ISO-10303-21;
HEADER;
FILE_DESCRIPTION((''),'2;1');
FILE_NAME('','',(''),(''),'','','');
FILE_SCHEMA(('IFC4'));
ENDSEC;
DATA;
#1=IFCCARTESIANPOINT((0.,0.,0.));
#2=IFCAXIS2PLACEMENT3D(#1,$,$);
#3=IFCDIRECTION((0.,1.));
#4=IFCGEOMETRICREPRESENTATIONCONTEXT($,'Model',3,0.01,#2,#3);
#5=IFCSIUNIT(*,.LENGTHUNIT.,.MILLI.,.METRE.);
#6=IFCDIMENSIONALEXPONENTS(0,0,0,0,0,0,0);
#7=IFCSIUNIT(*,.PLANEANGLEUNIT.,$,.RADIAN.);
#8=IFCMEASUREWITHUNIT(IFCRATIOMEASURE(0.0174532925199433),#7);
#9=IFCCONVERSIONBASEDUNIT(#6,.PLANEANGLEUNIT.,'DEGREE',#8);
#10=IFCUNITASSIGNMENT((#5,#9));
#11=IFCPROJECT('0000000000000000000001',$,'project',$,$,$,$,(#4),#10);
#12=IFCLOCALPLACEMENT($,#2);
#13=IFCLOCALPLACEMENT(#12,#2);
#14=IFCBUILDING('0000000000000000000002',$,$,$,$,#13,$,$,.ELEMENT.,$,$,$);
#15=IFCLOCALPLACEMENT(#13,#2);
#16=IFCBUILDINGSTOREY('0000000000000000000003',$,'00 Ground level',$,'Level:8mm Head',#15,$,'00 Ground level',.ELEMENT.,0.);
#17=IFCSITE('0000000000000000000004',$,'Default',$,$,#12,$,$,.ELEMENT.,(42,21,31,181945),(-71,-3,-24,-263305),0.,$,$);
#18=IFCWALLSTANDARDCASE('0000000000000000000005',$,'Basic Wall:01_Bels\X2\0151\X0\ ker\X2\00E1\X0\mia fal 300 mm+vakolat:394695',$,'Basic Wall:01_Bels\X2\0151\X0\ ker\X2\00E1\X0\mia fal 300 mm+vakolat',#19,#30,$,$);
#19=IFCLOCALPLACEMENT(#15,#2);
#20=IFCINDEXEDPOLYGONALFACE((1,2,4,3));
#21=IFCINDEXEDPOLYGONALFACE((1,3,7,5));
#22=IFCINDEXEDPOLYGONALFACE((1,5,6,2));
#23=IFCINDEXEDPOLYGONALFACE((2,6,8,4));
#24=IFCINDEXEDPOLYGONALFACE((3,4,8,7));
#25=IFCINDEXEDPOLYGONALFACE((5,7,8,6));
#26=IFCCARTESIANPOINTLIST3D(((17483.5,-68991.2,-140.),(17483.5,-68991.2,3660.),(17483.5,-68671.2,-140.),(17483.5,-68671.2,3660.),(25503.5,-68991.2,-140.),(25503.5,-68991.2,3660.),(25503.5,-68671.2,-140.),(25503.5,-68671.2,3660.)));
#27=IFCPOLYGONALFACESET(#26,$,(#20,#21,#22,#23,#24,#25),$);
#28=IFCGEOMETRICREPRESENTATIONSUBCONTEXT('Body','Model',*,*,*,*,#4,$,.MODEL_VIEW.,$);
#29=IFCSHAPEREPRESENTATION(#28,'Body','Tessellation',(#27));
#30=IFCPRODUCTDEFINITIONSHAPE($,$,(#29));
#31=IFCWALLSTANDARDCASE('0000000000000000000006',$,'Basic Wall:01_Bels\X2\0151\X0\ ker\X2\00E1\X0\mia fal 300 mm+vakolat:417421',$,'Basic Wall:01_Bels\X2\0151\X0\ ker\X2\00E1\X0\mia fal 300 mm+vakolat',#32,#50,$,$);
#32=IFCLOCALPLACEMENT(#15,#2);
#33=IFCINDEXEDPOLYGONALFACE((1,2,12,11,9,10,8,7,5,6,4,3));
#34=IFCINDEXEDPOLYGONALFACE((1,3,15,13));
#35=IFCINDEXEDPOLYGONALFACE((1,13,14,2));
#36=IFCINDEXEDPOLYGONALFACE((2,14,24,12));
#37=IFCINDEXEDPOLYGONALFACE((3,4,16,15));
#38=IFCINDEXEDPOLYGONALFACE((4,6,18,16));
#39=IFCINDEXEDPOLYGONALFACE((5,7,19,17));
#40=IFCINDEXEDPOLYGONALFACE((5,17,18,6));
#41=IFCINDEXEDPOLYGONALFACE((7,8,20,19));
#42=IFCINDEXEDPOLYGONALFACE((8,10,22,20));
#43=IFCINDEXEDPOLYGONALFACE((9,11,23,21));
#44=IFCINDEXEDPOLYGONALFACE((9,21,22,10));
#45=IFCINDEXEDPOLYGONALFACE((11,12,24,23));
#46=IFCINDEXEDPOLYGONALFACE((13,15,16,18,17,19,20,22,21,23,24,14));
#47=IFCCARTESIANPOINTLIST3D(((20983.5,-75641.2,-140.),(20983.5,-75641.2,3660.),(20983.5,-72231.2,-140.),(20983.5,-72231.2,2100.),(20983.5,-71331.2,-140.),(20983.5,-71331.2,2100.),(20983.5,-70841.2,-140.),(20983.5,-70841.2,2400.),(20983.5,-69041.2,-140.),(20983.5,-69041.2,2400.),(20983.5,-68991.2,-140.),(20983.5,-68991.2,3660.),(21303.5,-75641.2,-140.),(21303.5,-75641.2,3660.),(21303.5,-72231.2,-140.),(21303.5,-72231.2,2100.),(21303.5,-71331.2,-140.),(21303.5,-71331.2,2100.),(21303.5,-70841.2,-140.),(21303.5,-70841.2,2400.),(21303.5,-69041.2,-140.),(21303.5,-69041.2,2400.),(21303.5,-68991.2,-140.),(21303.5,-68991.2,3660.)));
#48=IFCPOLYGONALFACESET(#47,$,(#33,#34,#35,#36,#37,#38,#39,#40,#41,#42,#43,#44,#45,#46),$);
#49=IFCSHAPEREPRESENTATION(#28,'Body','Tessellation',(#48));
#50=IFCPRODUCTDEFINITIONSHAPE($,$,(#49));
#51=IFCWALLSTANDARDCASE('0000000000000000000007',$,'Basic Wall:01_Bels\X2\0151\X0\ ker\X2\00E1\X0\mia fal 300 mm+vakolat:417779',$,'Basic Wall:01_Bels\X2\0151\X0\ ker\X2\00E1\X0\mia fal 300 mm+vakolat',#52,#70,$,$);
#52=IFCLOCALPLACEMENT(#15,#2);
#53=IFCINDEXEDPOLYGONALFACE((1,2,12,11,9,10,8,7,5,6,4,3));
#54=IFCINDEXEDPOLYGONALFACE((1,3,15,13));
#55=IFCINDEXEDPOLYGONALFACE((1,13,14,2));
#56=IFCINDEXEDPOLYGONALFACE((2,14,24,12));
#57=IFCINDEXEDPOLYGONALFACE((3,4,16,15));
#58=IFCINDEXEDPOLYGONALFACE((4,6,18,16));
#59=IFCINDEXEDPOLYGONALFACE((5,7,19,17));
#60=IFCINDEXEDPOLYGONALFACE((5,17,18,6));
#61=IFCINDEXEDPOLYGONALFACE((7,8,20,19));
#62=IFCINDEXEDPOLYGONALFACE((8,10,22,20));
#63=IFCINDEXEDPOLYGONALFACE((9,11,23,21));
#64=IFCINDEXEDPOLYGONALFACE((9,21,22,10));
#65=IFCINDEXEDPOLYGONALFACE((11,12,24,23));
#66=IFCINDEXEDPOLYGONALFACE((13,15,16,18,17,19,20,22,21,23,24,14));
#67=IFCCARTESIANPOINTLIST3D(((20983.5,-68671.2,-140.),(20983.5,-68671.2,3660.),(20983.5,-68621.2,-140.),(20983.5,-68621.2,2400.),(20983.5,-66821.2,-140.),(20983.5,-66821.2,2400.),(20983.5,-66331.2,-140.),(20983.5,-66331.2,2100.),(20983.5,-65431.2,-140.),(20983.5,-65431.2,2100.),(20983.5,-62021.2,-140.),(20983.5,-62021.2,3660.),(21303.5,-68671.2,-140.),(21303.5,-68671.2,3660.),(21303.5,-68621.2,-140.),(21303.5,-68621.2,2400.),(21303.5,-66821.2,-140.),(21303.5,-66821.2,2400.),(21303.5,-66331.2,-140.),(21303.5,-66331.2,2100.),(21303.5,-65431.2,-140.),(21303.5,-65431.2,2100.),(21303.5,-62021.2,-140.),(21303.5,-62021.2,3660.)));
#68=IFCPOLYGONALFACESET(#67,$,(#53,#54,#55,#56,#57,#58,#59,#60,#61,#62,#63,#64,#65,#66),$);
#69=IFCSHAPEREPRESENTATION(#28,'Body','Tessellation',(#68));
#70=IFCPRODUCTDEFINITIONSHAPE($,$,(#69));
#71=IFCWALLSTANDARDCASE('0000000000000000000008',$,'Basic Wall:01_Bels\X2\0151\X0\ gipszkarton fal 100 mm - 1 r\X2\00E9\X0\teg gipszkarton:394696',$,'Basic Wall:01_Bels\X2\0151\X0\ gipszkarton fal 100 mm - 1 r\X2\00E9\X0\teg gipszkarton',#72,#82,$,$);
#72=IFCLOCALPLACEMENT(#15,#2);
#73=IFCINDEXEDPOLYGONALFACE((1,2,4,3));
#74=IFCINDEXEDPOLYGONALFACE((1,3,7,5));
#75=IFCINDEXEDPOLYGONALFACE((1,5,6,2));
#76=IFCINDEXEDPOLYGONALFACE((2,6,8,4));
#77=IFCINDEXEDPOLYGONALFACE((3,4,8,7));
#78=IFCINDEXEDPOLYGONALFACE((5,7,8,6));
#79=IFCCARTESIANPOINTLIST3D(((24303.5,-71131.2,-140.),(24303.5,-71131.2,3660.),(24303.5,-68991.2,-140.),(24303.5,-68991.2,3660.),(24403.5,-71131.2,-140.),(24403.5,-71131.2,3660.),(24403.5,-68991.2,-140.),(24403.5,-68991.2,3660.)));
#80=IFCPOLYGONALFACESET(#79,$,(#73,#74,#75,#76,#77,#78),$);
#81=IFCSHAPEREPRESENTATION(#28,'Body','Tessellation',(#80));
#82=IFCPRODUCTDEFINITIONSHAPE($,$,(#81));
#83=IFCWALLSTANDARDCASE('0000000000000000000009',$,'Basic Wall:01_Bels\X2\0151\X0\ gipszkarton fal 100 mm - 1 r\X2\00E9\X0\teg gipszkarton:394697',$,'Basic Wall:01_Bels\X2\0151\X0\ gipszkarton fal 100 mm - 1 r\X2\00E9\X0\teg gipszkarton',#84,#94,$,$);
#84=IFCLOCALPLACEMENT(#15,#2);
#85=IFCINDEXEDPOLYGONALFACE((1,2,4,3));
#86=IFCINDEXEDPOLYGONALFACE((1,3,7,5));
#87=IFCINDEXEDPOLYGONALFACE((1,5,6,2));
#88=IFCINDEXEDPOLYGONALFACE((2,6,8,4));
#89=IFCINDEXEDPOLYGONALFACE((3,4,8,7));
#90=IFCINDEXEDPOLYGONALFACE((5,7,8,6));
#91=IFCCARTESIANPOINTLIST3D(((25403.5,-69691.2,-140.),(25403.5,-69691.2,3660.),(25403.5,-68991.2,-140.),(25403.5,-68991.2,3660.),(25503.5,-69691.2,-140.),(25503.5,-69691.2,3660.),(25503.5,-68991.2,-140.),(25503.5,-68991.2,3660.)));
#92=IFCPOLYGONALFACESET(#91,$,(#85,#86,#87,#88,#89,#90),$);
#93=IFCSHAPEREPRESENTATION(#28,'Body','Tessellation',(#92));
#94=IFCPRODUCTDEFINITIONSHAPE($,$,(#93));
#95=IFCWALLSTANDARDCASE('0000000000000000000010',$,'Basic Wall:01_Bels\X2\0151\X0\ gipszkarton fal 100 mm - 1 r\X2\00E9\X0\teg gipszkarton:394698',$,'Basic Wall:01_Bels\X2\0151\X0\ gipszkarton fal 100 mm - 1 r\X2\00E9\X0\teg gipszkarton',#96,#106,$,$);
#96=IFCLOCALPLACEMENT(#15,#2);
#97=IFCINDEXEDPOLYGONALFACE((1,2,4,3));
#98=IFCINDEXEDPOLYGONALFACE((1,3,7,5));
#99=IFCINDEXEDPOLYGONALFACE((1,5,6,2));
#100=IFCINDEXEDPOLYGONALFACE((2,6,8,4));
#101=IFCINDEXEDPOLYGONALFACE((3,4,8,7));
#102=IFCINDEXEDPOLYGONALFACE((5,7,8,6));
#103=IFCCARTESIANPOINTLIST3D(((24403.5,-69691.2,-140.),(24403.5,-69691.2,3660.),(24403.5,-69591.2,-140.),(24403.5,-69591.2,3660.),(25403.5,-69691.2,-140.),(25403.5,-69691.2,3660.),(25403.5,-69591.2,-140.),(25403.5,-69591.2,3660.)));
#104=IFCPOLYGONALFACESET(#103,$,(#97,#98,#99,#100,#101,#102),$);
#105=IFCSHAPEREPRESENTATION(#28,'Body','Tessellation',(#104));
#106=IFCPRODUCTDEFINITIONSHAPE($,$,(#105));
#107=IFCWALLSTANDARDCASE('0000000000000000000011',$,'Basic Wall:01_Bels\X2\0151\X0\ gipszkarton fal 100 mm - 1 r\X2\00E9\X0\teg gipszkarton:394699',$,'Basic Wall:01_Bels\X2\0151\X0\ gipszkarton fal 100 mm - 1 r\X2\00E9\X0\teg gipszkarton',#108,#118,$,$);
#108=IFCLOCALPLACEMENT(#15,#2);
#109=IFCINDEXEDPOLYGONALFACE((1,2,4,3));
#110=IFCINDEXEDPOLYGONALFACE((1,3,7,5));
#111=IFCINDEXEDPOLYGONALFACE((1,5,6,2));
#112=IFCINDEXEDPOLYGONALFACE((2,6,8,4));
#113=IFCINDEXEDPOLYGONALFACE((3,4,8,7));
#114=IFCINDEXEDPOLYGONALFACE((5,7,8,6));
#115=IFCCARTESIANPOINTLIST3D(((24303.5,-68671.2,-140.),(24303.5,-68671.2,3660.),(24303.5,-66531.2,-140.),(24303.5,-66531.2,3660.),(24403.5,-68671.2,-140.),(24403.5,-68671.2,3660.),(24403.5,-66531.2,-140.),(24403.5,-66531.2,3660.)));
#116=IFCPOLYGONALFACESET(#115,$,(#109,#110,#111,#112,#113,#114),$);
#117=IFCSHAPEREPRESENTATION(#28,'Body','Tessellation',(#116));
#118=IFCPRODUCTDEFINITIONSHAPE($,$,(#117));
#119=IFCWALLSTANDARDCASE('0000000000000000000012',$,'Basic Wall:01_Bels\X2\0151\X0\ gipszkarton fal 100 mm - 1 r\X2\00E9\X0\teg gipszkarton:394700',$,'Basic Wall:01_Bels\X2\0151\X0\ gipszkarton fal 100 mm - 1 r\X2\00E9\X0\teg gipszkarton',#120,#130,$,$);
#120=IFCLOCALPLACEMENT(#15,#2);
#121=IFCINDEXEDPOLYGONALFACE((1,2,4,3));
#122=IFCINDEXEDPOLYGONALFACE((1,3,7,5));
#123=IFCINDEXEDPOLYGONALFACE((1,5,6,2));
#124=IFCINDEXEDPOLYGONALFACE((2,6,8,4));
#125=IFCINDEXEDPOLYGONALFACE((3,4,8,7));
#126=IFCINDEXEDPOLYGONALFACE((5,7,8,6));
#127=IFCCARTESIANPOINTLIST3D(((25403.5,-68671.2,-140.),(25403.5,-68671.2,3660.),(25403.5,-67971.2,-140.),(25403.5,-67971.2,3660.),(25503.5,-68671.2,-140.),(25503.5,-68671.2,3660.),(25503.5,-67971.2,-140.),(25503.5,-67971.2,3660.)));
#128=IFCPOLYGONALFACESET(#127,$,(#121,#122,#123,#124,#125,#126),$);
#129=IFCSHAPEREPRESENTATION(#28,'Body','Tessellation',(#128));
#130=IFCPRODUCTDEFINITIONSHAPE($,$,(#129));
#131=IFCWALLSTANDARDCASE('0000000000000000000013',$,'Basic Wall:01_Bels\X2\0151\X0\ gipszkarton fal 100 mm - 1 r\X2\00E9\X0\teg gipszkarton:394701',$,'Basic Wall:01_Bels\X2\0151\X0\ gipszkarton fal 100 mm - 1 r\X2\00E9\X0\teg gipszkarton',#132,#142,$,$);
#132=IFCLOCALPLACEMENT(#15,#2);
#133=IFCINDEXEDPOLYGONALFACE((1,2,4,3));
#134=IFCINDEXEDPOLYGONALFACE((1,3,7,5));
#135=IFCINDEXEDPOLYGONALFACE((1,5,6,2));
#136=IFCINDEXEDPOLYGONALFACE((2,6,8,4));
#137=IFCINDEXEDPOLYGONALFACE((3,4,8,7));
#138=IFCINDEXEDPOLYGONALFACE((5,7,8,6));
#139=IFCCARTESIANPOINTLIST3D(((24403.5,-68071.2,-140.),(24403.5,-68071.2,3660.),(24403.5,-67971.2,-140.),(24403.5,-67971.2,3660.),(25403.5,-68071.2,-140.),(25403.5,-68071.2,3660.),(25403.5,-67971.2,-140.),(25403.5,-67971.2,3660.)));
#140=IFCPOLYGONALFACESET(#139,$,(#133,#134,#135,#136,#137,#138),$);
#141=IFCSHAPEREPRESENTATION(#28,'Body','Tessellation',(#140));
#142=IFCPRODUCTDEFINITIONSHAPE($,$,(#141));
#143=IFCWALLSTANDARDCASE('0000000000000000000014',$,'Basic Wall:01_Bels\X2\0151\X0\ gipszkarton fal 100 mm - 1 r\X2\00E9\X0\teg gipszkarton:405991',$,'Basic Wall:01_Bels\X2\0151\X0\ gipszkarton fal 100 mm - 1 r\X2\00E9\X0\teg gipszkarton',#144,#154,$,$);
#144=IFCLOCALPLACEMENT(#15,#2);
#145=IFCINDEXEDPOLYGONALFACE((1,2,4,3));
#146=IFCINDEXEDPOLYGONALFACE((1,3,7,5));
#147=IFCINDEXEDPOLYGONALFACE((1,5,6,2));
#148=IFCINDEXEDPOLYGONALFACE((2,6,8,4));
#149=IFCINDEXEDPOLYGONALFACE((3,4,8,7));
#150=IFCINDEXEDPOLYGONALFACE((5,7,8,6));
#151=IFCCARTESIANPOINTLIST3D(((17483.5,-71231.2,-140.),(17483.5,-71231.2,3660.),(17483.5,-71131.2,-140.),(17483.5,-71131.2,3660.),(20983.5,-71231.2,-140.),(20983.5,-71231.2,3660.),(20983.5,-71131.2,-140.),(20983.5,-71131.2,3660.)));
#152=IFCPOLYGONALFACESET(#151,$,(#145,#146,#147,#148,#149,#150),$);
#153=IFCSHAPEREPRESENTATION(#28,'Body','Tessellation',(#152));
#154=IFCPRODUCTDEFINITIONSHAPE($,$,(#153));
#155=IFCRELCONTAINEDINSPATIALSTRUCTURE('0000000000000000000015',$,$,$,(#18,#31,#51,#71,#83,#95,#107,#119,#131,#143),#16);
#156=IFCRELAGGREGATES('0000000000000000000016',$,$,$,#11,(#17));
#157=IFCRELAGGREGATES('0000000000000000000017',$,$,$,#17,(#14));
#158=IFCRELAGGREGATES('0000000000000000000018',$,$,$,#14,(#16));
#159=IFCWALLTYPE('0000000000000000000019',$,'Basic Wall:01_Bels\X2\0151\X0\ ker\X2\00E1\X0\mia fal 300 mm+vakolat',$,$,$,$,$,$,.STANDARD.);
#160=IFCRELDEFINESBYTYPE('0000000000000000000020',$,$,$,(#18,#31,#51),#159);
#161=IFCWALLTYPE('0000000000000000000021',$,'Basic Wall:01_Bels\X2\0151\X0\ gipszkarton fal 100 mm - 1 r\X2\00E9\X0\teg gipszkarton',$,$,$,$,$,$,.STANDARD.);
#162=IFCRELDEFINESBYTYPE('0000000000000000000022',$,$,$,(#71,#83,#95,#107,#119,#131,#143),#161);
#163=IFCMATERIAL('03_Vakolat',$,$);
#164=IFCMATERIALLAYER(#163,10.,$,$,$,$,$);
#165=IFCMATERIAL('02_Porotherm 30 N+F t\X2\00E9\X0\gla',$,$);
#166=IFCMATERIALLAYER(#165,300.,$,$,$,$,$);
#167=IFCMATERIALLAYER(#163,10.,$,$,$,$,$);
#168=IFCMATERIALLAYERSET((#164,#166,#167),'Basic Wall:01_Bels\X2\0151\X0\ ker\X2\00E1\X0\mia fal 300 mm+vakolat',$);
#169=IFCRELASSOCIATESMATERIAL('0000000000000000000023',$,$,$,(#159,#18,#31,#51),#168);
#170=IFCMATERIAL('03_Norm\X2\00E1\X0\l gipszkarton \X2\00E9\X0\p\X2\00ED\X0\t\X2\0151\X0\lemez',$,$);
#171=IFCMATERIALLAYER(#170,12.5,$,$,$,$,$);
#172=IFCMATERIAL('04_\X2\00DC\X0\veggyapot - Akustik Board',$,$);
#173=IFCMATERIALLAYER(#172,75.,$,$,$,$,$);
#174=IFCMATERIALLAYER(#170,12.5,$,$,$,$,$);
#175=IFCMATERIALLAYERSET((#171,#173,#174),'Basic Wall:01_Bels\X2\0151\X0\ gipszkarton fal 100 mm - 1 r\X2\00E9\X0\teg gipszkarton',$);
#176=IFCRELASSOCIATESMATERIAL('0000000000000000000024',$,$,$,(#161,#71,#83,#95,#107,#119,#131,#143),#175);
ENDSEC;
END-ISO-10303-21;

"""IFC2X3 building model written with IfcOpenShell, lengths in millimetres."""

from ifc_helpers import new_model, entity, si_unit, converted_unit, direction, frame, frame_2d, origin, origin_2d_with_axis, place, context, subcontext, project, spatial, rectangle, extrude, material, layer, layer_set, layer_usage, type_object, element, save


model = new_model("IFC2X3")

# Units and contexts
model_context = context("Model", 3, precision=0.01, world=origin(), true_north=direction((0.0, 1.0)))
body_context = subcontext(model_context, "Body", "Model", "MODEL_VIEW")
ifc_project = project(units=[si_unit("LENGTHUNIT", "METRE", prefix="MILLI"), converted_unit("PLANEANGLEUNIT", "DEGREE", entity("IfcRatioMeasure", 0.0174532925199433), si_unit("PLANEANGLEUNIT", "RADIAN"), dimensions=[0, 0, 0, 0, 0, 0, 0])], contexts=[model_context])

# Site, building, storey
site_placement = place(None, origin())
site = spatial("IfcSite", under=ifc_project, at=site_placement, Name="Default", CompositionType="ELEMENT", RefLatitude=(42, 21, 31, 181945), RefLongitude=(-71, -3, -24, -263305), RefElevation=0.0)
building_placement = place(site_placement, origin())
building = spatial("IfcBuilding", under=site, at=building_placement, CompositionType="ELEMENT")
storey_placement = place(building_placement, origin())
storey = spatial("IfcBuildingStorey", under=building, at=storey_placement, Name="00 Ground level", ObjectType="Level:8mm Head", LongName="00 Ground level", CompositionType="ELEMENT", Elevation=0.0)

# Wall
ifc_material_1 = material(Name="03_Vakolat")
ifc_layer_1 = layer(ifc_material_1, 10.0)
ifc_material_2 = material(Name="02_Porotherm 30 N+F tégla")
ifc_layer_2 = layer(ifc_material_2, 300.0)
ifc_layer_3 = layer(ifc_material_1, 10.0)
ifc_layer_set_1 = layer_set([ifc_layer_1, ifc_layer_2, ifc_layer_3], Name="Basic Wall:01_Belső kerámia fal 300 mm+vakolat")
ifc_layer_usage_1 = layer_usage(ifc_layer_set_1, "AXIS2", "NEGATIVE", 160.0)
wall_type_1 = type_object("IfcWallType", Name="Basic Wall:01_Belső kerámia fal 300 mm+vakolat", PredefinedType="STANDARD", material=ifc_layer_set_1)
wall_1_placement = place(storey_placement, frame((17483.5, -68831.2, -140.0)))
element("IfcWallStandardCase", 1, at=wall_1_placement, inside=storey, type_object=wall_type_1, material=ifc_layer_usage_1, Name="Basic Wall:01_Belső kerámia fal 300 mm+vakolat:394695", ObjectType="Basic Wall:01_Belső kerámia fal 300 mm+vakolat", context=body_context, shape_type="SweptSolid", body=[
    extrude(rectangle(XDim=8020.0, YDim=320.0, at=frame_2d((4010.0, 0.0), x_axis=(-1.0, 0.0))), origin(), (0.0, 0.0, 1.0), 3800.0),
])

# Walls, openings
ifc_layer_usage_2 = layer_usage(ifc_layer_set_1, "AXIS2", "NEGATIVE", 160.0)
wall_2_placement = place(storey_placement, frame((21143.5, -75641.2, -140.0), z_axis=(0.0, 0.0, 1.0), x_axis=(0.0, 1.0, 0.0)))
wall_2 = element("IfcWallStandardCase", 2, at=wall_2_placement, inside=storey, type_object=wall_type_1, material=ifc_layer_usage_2, Name="Basic Wall:01_Belső kerámia fal 300 mm+vakolat:417421", ObjectType="Basic Wall:01_Belső kerámia fal 300 mm+vakolat", context=body_context, shape_type="SweptSolid", body=[
    extrude(rectangle(XDim=6650.0, YDim=320.0, at=frame_2d((3325.0, 0.0), x_axis=(-1.0, 0.0))), origin(), (0.0, 0.0, 1.0), 3800.0),
])
opening_1_placement = place(wall_2_placement, frame((4800.0, 160.0, 0.0)))
element("IfcOpeningElement", 3, at=opening_1_placement, cuts=wall_2, ObjectType="Opening", context=body_context, shape_type="SweptSolid", body=[
    extrude(rectangle(XDim=2540.0, YDim=1800.0, at=frame_2d((0.0, 0.0), x_axis=(1.0, 0.0))), frame((900.0, -320.0, 1270.0), z_axis=(0.0, 1.0, 0.0), x_axis=(0.0, 0.0, -1.0)), (0.0, 0.0, 1.0), 320.0),
])
opening_2_placement = place(wall_2_placement, frame((3410.0, 1364.0, 0.0), z_axis=(0.0, 0.0, 1.0), x_axis=(0.0, -1.0, 0.0)))
element("IfcOpeningElement", 4, at=opening_2_placement, cuts=wall_2, ObjectType="Opening", context=body_context, shape_type="SweptSolid", body=[
    extrude(rectangle(XDim=2240.0, YDim=900.0, at=origin_2d_with_axis()), frame((3048.0, 450.0, 1120.0), z_axis=(-1.0, 0.0, 0.0), x_axis=(0.0, 0.0, 1.0)), (0.0, 0.0, 1.0), 3048.0),
])
ifc_layer_usage_3 = layer_usage(ifc_layer_set_1, "AXIS2", "POSITIVE", -160.0)
wall_3_placement = place(storey_placement, frame((21143.5, -62021.2, -140.0), z_axis=(0.0, 0.0, 1.0), x_axis=(0.0, -1.0, 0.0)))
wall_3 = element("IfcWallStandardCase", 5, at=wall_3_placement, inside=storey, type_object=wall_type_1, material=ifc_layer_usage_3, Name="Basic Wall:01_Belső kerámia fal 300 mm+vakolat:417779", ObjectType="Basic Wall:01_Belső kerámia fal 300 mm+vakolat", context=body_context, shape_type="SweptSolid", body=[
    extrude(rectangle(XDim=6650.0, YDim=320.0, at=frame_2d((3325.0, 0.0), x_axis=(-1.0, 0.0))), origin(), (0.0, 0.0, 1.0), 3800.0),
])
opening_3_placement = place(wall_3_placement, frame((6600.0, -160.0, 0.0)))
element("IfcOpeningElement", 6, at=opening_3_placement, cuts=wall_3, ObjectType="Opening", context=body_context, shape_type="SweptSolid", body=[
    extrude(rectangle(XDim=2540.0, YDim=1800.0, at=frame_2d((0.0, 0.0), x_axis=(1.0, 0.0))), frame((-900.0, 0.0, 1270.0), z_axis=(0.0, 1.0, 0.0), x_axis=(0.0, 0.0, -1.0)), (0.0, 0.0, 1.0), 320.0),
])
opening_4_placement = place(wall_3_placement, frame((4310.0, -1364.0, 0.0), z_axis=(0.0, 0.0, 1.0), x_axis=(0.0, 1.0, 0.0)))
element("IfcOpeningElement", 7, at=opening_4_placement, cuts=wall_3, ObjectType="Opening", context=body_context, shape_type="SweptSolid", body=[
    extrude(rectangle(XDim=2240.0, YDim=900.0, at=origin_2d_with_axis()), frame((0.0, 450.0, 1120.0), z_axis=(1.0, 0.0, 0.0), x_axis=(0.0, 0.0, 1.0)), (0.0, 0.0, 1.0), 3048.0),
])

# Walls
ifc_material_3 = material(Name="03_Normál gipszkarton építőlemez")
ifc_layer_4 = layer(ifc_material_3, 12.5)
ifc_material_4 = material(Name="04_Üveggyapot - Akustik Board")
ifc_layer_5 = layer(ifc_material_4, 75.0)
ifc_layer_6 = layer(ifc_material_3, 12.5)
ifc_layer_set_2 = layer_set([ifc_layer_4, ifc_layer_5, ifc_layer_6], Name="Basic Wall:01_Belső gipszkarton fal 100 mm - 1 réteg gipszkarton")
ifc_layer_usage_4 = layer_usage(ifc_layer_set_2, "AXIS2", "NEGATIVE", 50.0)
wall_type_2 = type_object("IfcWallType", Name="Basic Wall:01_Belső gipszkarton fal 100 mm - 1 réteg gipszkarton", PredefinedType="STANDARD", material=ifc_layer_set_2)
wall_4_placement = place(storey_placement, frame((24353.5, -71131.2, -140.0), z_axis=(0.0, 0.0, 1.0), x_axis=(0.0, 1.0, 0.0)))
element("IfcWallStandardCase", 8, at=wall_4_placement, inside=storey, type_object=wall_type_2, material=ifc_layer_usage_4, Name="Basic Wall:01_Belső gipszkarton fal 100 mm - 1 réteg gipszkarton:394696", ObjectType="Basic Wall:01_Belső gipszkarton fal 100 mm - 1 réteg gipszkarton", context=body_context, shape_type="SweptSolid", body=[
    extrude(rectangle(XDim=2140.0, YDim=100.0, at=frame_2d((1070.0, 0.0), x_axis=(-1.0, 0.0))), origin(), (0.0, 0.0, 1.0), 3800.0),
])
ifc_layer_usage_5 = layer_usage(ifc_layer_set_2, "AXIS2", "NEGATIVE", 50.0)
wall_5_placement = place(storey_placement, frame((25453.5, -69691.2, -140.0), z_axis=(0.0, 0.0, 1.0), x_axis=(0.0, 1.0, 0.0)))
element("IfcWallStandardCase", 9, at=wall_5_placement, inside=storey, type_object=wall_type_2, material=ifc_layer_usage_5, Name="Basic Wall:01_Belső gipszkarton fal 100 mm - 1 réteg gipszkarton:394697", ObjectType="Basic Wall:01_Belső gipszkarton fal 100 mm - 1 réteg gipszkarton", context=body_context, shape_type="SweptSolid", body=[
    extrude(rectangle(XDim=700.0, YDim=100.0, at=frame_2d((350.0, 0.0), x_axis=(-1.0, 0.0))), origin(), (0.0, 0.0, 1.0), 3800.0),
])
ifc_layer_usage_6 = layer_usage(ifc_layer_set_2, "AXIS2", "NEGATIVE", 50.0)
wall_6_placement = place(storey_placement, frame((24403.5, -69641.2, -140.0)))
element("IfcWallStandardCase", 10, at=wall_6_placement, inside=storey, type_object=wall_type_2, material=ifc_layer_usage_6, Name="Basic Wall:01_Belső gipszkarton fal 100 mm - 1 réteg gipszkarton:394698", ObjectType="Basic Wall:01_Belső gipszkarton fal 100 mm - 1 réteg gipszkarton", context=body_context, shape_type="SweptSolid", body=[
    extrude(rectangle(XDim=1000.0, YDim=100.0, at=frame_2d((500.0, 0.0), x_axis=(-1.0, 0.0))), origin(), (0.0, 0.0, 1.0), 3800.0),
])
ifc_layer_usage_7 = layer_usage(ifc_layer_set_2, "AXIS2", "POSITIVE", -50.0)
wall_7_placement = place(storey_placement, frame((24353.5, -66531.2, -140.0), z_axis=(0.0, 0.0, 1.0), x_axis=(0.0, -1.0, 0.0)))
element("IfcWallStandardCase", 11, at=wall_7_placement, inside=storey, type_object=wall_type_2, material=ifc_layer_usage_7, Name="Basic Wall:01_Belső gipszkarton fal 100 mm - 1 réteg gipszkarton:394699", ObjectType="Basic Wall:01_Belső gipszkarton fal 100 mm - 1 réteg gipszkarton", context=body_context, shape_type="SweptSolid", body=[
    extrude(rectangle(XDim=2140.0, YDim=100.0, at=frame_2d((1070.0, 0.0), x_axis=(-1.0, 0.0))), origin(), (0.0, 0.0, 1.0), 3800.0),
])
ifc_layer_usage_8 = layer_usage(ifc_layer_set_2, "AXIS2", "POSITIVE", -50.0)
wall_8_placement = place(storey_placement, frame((25453.5, -67971.2, -140.0), z_axis=(0.0, 0.0, 1.0), x_axis=(0.0, -1.0, 0.0)))
element("IfcWallStandardCase", 12, at=wall_8_placement, inside=storey, type_object=wall_type_2, material=ifc_layer_usage_8, Name="Basic Wall:01_Belső gipszkarton fal 100 mm - 1 réteg gipszkarton:394700", ObjectType="Basic Wall:01_Belső gipszkarton fal 100 mm - 1 réteg gipszkarton", context=body_context, shape_type="SweptSolid", body=[
    extrude(rectangle(XDim=700.0, YDim=100.0, at=frame_2d((350.0, 0.0), x_axis=(-1.0, 0.0))), origin(), (0.0, 0.0, 1.0), 3800.0),
])
ifc_layer_usage_9 = layer_usage(ifc_layer_set_2, "AXIS2", "POSITIVE", -50.0)
wall_9_placement = place(storey_placement, frame((24403.5, -68021.2, -140.0)))
element("IfcWallStandardCase", 13, at=wall_9_placement, inside=storey, type_object=wall_type_2, material=ifc_layer_usage_9, Name="Basic Wall:01_Belső gipszkarton fal 100 mm - 1 réteg gipszkarton:394701", ObjectType="Basic Wall:01_Belső gipszkarton fal 100 mm - 1 réteg gipszkarton", context=body_context, shape_type="SweptSolid", body=[
    extrude(rectangle(XDim=1000.0, YDim=100.0, at=frame_2d((500.0, 0.0), x_axis=(-1.0, 0.0))), origin(), (0.0, 0.0, 1.0), 3800.0),
])
ifc_layer_usage_10 = layer_usage(ifc_layer_set_2, "AXIS2", "NEGATIVE", 50.0)
wall_10_placement = place(storey_placement, frame((17483.5, -71181.2, -140.0)))
element("IfcWallStandardCase", 14, at=wall_10_placement, inside=storey, type_object=wall_type_2, material=ifc_layer_usage_10, Name="Basic Wall:01_Belső gipszkarton fal 100 mm - 1 réteg gipszkarton:405991", ObjectType="Basic Wall:01_Belső gipszkarton fal 100 mm - 1 réteg gipszkarton", context=body_context, shape_type="SweptSolid", body=[
    extrude(rectangle(XDim=3500.0, YDim=100.0, at=frame_2d((1750.0, 0.0), x_axis=(-1.0, 0.0))), origin(), (0.0, 0.0, 1.0), 3800.0),
])

save(model, "model.ifc")
